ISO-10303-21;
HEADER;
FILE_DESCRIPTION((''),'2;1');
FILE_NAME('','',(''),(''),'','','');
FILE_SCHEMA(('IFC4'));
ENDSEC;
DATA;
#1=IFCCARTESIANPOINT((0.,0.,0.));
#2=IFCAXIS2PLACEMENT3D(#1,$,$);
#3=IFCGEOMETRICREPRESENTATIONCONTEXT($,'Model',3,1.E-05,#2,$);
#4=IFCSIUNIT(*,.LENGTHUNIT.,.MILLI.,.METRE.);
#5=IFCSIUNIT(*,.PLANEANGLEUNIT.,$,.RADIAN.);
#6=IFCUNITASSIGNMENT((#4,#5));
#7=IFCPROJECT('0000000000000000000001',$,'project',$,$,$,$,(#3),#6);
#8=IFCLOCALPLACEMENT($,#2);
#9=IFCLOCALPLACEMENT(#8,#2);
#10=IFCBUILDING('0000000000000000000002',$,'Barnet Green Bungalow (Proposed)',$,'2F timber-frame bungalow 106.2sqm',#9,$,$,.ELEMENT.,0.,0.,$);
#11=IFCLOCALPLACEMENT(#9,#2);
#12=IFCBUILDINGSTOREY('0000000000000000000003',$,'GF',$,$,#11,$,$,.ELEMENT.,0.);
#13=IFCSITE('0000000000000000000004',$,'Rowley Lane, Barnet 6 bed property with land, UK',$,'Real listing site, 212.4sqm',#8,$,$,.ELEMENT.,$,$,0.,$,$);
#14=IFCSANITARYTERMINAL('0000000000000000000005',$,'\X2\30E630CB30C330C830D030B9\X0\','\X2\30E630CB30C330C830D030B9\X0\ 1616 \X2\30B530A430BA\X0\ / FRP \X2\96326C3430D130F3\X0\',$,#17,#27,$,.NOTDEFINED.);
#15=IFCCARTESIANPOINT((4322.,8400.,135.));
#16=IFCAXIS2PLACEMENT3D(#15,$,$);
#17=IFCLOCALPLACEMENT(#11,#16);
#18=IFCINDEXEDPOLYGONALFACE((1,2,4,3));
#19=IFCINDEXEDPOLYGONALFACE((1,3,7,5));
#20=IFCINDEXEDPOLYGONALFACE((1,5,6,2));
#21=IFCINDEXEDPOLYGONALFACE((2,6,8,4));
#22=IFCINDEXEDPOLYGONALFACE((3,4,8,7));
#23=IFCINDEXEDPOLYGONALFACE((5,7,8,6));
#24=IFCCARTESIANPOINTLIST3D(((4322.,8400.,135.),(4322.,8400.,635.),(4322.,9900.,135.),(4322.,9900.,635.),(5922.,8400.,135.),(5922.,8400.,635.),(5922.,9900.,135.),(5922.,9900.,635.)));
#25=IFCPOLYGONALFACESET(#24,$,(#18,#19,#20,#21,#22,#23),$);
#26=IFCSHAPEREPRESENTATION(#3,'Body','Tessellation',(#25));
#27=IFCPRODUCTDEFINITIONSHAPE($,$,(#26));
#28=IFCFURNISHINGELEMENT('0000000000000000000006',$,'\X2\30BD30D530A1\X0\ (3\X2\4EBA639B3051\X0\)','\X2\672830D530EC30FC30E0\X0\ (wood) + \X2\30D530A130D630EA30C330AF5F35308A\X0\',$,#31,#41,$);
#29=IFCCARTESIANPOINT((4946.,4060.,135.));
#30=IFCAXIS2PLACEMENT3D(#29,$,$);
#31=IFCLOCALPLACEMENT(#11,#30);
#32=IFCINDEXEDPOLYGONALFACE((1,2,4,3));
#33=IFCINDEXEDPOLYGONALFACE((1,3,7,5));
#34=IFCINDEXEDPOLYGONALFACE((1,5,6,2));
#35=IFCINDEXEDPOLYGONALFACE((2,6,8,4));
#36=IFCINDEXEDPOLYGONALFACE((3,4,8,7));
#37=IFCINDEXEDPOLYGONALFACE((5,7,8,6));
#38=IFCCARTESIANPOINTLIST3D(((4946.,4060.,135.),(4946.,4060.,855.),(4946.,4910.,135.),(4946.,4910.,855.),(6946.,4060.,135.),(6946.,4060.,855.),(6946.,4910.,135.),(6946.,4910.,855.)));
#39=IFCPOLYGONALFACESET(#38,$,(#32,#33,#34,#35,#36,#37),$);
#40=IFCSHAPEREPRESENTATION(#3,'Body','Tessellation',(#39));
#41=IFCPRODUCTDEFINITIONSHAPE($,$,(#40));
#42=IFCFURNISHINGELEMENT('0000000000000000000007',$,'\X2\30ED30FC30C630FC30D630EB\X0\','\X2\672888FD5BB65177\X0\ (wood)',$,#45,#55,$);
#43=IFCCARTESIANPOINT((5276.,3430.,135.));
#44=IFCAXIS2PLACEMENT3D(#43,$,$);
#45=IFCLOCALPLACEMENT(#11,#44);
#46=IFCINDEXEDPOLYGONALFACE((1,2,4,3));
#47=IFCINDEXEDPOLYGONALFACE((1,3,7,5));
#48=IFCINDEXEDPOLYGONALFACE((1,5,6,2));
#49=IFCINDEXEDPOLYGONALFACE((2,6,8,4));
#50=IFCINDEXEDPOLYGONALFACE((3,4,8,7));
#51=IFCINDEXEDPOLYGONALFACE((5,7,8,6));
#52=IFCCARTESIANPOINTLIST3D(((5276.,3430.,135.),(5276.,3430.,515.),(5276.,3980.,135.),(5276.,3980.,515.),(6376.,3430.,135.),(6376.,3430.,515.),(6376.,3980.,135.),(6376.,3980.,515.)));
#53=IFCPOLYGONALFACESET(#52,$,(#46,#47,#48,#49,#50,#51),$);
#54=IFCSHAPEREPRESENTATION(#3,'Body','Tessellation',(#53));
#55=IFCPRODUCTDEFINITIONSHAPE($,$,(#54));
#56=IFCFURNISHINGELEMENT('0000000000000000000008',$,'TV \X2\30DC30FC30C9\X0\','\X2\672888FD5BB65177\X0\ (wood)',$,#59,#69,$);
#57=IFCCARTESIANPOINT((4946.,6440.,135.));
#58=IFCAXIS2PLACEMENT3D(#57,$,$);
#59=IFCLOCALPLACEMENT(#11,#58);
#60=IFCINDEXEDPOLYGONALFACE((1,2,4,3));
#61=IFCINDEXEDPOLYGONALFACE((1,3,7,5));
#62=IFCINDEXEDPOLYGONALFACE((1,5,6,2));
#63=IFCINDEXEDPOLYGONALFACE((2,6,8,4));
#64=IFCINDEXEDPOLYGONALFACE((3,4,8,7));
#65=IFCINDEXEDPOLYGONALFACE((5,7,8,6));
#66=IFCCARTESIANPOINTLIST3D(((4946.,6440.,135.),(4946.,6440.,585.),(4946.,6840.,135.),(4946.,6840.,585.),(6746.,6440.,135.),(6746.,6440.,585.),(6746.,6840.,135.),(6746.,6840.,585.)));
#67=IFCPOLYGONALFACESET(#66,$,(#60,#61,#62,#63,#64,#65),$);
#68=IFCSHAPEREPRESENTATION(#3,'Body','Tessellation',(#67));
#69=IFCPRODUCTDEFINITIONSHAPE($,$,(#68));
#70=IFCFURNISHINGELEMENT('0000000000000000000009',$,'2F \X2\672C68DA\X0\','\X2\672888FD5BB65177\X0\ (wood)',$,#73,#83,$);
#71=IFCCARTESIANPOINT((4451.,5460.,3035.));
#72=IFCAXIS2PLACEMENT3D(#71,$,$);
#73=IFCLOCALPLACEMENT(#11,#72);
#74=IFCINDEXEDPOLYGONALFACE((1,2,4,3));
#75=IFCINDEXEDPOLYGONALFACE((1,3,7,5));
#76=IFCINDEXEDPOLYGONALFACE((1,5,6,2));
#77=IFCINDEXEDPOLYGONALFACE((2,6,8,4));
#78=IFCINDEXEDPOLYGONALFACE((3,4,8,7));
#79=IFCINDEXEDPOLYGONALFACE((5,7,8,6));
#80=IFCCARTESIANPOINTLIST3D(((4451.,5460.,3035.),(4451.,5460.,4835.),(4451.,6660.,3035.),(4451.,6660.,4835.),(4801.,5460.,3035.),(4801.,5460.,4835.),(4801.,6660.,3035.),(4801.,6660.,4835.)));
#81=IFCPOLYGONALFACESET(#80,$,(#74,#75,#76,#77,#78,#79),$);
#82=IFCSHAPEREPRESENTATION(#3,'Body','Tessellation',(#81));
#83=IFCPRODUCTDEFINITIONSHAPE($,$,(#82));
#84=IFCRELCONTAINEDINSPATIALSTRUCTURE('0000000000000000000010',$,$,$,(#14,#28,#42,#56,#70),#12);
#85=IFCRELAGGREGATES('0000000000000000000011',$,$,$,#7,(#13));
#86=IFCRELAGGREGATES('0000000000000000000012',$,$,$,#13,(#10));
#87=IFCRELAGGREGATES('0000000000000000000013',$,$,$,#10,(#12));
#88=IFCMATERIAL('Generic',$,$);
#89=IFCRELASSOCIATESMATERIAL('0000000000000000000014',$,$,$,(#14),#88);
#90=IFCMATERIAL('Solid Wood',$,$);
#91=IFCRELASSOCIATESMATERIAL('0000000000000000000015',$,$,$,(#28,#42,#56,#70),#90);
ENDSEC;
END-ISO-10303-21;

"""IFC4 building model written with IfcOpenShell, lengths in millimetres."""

from ifc_helpers import new_model, si_unit, frame, frame_2d, origin, place, context, project, spatial, rectangle, extrude, material, element, save


model = new_model("IFC4")

# Units and contexts
model_context = context("Model", 3, precision=1e-05, world=origin())
ifc_project = project(units=[si_unit("LENGTHUNIT", "METRE", prefix="MILLI"), si_unit("PLANEANGLEUNIT", "RADIAN")], contexts=[model_context])

# Site, building, storey
site_placement = place(None, origin())
site = spatial("IfcSite", under=ifc_project, at=site_placement, Name="Rowley Lane, Barnet 6 bed property with land, UK", ObjectType="Real listing site, 212.4sqm", CompositionType="ELEMENT", RefElevation=0.0)
building_placement = place(site_placement, origin())
building = spatial("IfcBuilding", under=site, at=building_placement, Name="Barnet Green Bungalow (Proposed)", ObjectType="2F timber-frame bungalow 106.2sqm", CompositionType="ELEMENT", ElevationOfRefHeight=0.0, ElevationOfTerrain=0.0)
storey_placement = place(building_placement, origin())
storey = spatial("IfcBuildingStorey", under=building, at=storey_placement, Name="GF", CompositionType="ELEMENT", Elevation=0.0)

# Shared definitions
ifc_material_1 = material(Name="Solid Wood")

# Sanitary terminal
ifc_material_2 = material(Name="Generic")
sanitary_terminal_placement = place(storey_placement, frame((4322.0, 8400.0, 135.0)))
element("IfcSanitaryTerminal", 1, at=sanitary_terminal_placement, inside=storey, material=ifc_material_2, Name="ユニットバス", Description="ユニットバス 1616 サイズ / FRP 防水パン", PredefinedType="NOTDEFINED", context=model_context, shape_type="SweptSolid", body=[
    extrude(rectangle(XDim=1600.0, YDim=1500.0, at=frame_2d((800.0, 750.0))), frame((4322.0, 8400.0, 135.0)), (0.0, 0.0, 1.0), 500.0),
])

# Furnishing elements
furnishing_1_placement = place(storey_placement, frame((4946.0, 4060.0, 135.0)))
element("IfcFurnishingElement", 2, at=furnishing_1_placement, inside=storey, material=ifc_material_1, Name="ソファ (3人掛け)", Description="木フレーム (wood) + ファブリック張り", context=model_context, shape_type="SweptSolid", body=[
    extrude(rectangle(XDim=2000.0, YDim=850.0, at=frame_2d((1000.0, 425.0))), frame((4946.0, 4060.0, 135.0)), (0.0, 0.0, 1.0), 720.0),
])
furnishing_2_placement = place(storey_placement, frame((5276.0, 3430.0, 135.0)))
element("IfcFurnishingElement", 3, at=furnishing_2_placement, inside=storey, material=ifc_material_1, Name="ローテーブル", Description="木製家具 (wood)", context=model_context, shape_type="SweptSolid", body=[
    extrude(rectangle(XDim=1100.0, YDim=550.0, at=frame_2d((550.0, 275.0))), frame((5276.0, 3430.0, 135.0)), (0.0, 0.0, 1.0), 380.0),
])
furnishing_3_placement = place(storey_placement, frame((4946.0, 6440.0, 135.0)))
element("IfcFurnishingElement", 4, at=furnishing_3_placement, inside=storey, material=ifc_material_1, Name="TV ボード", Description="木製家具 (wood)", context=model_context, shape_type="SweptSolid", body=[
    extrude(rectangle(XDim=1800.0, YDim=400.0, at=frame_2d((900.0, 200.0))), frame((4946.0, 6440.0, 135.0)), (0.0, 0.0, 1.0), 450.0),
])
furnishing_4_placement = place(storey_placement, frame((4451.0, 5460.0, 3035.0)))
element("IfcFurnishingElement", 5, at=furnishing_4_placement, inside=storey, material=ifc_material_1, Name="2F 本棚", Description="木製家具 (wood)", context=model_context, shape_type="SweptSolid", body=[
    extrude(rectangle(XDim=350.0, YDim=1200.0, at=frame_2d((175.0, 600.0))), frame((4451.0, 5460.0, 3035.0)), (0.0, 0.0, 1.0), 1800.0),
])

save(model, "model.ifc")
